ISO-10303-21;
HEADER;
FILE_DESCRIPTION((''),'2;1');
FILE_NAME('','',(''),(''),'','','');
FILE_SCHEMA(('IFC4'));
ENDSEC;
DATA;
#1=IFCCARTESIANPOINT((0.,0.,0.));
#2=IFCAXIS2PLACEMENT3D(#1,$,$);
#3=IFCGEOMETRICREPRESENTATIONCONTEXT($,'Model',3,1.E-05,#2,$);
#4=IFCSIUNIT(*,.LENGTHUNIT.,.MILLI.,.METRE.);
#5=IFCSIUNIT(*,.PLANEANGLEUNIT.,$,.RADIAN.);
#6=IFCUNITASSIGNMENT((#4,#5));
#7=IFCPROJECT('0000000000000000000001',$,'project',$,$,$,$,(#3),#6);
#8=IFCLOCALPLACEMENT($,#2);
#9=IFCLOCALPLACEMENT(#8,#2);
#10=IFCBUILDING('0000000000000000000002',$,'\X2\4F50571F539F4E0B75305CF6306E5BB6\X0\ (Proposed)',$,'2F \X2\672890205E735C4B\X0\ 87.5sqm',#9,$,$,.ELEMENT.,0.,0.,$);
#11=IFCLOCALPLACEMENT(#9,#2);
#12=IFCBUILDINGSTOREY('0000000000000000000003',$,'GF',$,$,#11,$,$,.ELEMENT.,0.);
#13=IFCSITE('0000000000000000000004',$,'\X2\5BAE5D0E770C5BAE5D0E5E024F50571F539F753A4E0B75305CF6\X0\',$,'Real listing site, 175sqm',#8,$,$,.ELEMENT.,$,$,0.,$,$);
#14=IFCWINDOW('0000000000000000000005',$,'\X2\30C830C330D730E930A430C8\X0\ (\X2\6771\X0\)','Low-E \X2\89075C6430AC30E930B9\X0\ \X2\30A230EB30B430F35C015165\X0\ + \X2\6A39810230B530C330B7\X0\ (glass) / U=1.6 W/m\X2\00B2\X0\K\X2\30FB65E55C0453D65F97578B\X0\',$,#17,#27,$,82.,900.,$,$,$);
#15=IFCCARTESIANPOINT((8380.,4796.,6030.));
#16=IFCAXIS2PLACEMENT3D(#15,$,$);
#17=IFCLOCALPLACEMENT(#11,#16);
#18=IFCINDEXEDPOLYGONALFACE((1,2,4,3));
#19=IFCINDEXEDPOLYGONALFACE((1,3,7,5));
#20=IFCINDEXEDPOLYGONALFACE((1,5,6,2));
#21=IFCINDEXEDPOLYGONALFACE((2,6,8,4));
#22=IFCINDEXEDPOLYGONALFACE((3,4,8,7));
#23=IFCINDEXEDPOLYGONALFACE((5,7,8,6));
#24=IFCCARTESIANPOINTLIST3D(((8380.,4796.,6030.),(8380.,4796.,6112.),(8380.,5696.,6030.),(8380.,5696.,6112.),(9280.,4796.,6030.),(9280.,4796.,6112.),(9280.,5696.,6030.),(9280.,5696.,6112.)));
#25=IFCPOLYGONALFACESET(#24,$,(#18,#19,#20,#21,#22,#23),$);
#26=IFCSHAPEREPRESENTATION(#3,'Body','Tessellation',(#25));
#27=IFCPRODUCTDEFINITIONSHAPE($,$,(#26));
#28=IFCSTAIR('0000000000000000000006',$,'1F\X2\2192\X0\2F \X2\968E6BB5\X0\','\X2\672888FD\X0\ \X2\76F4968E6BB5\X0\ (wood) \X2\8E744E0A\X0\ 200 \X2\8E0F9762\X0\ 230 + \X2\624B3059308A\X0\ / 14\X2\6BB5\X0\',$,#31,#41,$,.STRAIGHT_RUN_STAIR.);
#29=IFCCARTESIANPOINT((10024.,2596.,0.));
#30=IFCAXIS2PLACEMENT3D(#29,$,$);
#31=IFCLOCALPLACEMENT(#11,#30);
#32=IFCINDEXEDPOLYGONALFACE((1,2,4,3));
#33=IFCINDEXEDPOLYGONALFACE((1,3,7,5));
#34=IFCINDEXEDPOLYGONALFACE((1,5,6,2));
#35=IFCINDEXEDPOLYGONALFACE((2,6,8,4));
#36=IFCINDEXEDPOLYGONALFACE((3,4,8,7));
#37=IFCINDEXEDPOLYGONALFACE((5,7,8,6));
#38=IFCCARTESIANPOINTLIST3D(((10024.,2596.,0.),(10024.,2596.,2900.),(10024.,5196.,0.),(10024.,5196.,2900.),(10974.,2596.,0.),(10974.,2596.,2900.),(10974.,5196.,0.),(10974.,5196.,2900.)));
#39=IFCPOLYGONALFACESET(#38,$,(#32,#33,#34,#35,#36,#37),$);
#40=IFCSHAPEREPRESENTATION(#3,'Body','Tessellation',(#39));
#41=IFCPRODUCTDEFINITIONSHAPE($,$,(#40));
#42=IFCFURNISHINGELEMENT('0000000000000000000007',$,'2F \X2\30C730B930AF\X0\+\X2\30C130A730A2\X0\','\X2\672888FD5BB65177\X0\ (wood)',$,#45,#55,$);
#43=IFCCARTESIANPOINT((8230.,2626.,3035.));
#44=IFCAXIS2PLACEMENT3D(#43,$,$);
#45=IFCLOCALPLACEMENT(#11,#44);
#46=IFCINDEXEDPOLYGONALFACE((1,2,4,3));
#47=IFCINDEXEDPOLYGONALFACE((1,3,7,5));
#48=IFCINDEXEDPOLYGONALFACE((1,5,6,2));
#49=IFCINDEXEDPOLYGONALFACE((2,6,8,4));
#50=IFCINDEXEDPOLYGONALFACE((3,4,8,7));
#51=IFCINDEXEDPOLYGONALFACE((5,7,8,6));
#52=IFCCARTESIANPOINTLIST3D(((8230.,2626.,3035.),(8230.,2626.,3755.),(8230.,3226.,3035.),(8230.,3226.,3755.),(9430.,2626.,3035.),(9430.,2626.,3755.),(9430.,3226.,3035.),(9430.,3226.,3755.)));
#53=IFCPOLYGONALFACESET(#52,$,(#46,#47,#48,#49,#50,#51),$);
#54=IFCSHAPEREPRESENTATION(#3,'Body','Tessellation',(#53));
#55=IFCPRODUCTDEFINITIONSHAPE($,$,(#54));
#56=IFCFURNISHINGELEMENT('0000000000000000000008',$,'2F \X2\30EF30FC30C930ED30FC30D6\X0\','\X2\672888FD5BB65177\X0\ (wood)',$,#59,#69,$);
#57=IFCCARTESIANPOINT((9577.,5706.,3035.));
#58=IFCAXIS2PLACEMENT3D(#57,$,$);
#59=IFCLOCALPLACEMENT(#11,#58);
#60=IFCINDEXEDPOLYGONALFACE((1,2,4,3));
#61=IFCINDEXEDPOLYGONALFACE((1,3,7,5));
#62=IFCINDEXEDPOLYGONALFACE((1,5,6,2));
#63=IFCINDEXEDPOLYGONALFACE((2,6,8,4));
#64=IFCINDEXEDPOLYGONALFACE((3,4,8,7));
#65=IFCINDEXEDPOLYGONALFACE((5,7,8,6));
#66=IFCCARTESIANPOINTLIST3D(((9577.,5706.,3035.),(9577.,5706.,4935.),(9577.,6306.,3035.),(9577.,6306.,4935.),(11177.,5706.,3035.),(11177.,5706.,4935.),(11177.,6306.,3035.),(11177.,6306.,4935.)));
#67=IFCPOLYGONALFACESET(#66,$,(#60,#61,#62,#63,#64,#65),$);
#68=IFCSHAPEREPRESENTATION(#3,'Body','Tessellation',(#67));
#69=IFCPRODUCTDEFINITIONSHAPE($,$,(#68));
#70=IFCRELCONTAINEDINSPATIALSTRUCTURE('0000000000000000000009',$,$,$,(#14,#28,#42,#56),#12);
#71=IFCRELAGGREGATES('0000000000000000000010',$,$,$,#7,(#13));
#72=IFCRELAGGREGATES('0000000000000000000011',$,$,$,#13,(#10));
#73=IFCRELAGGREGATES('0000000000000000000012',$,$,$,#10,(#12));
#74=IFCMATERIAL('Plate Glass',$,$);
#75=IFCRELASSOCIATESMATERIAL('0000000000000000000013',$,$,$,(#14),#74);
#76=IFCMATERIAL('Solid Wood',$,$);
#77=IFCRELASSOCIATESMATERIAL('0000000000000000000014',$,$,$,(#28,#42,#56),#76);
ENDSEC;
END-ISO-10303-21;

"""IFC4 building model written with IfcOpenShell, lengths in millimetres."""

from ifc_helpers import new_model, si_unit, frame, frame_2d, origin, place, context, project, spatial, rectangle, extrude, material, element, save


model = new_model("IFC4")

# Units and contexts
model_context = context("Model", 3, precision=1e-05, world=origin())
ifc_project = project(units=[si_unit("LENGTHUNIT", "METRE", prefix="MILLI"), si_unit("PLANEANGLEUNIT", "RADIAN")], contexts=[model_context])

# Site, building, storey
site_placement = place(None, origin())
site = spatial("IfcSite", under=ifc_project, at=site_placement, Name="宮崎県宮崎市佐土原町下田島", ObjectType="Real listing site, 175sqm", CompositionType="ELEMENT", RefElevation=0.0)
building_placement = place(site_placement, origin())
building = spatial("IfcBuilding", under=site, at=building_placement, Name="佐土原下田島の家 (Proposed)", ObjectType="2F 木造平屋 87.5sqm", CompositionType="ELEMENT", ElevationOfRefHeight=0.0, ElevationOfTerrain=0.0)
storey_placement = place(building_placement, origin())
storey = spatial("IfcBuildingStorey", under=building, at=storey_placement, Name="GF", CompositionType="ELEMENT", Elevation=0.0)

# Shared definitions
ifc_material_1 = material(Name="Solid Wood")

# Shared definitions
ifc_material_2 = material(Name="Plate Glass")

# Window
window_1_placement = place(storey_placement, frame((8380.0, 4796.0, 6030.0)))
element("IfcWindow", 1, at=window_1_placement, inside=storey, material=ifc_material_2, Name="トップライト (東)", Description="Low-E 複層ガラス アルゴン封入 + 樹脂サッシ (glass) / U=1.6 W/m²K・日射取得型", OverallHeight=82.0, OverallWidth=900.0, context=model_context, shape_type="SweptSolid", body=[
    extrude(rectangle(XDim=900.0, YDim=900.0, at=frame_2d((450.0, 450.0))), frame((8380.0, 4796.0, 6030.0)), (0.0, 0.0, 1.0), 82.0),
])

# Stair
stair_placement = place(storey_placement, frame((10024.0, 2596.0, 0.0)))
element("IfcStair", 2, at=stair_placement, inside=storey, material=ifc_material_1, Name="1F→2F 階段", Description="木製 直階段 (wood) 蹴上 200 踏面 230 + 手すり / 14段", PredefinedType="STRAIGHT_RUN_STAIR", context=model_context, shape_type="SweptSolid", body=[
    extrude(rectangle(XDim=950.0, YDim=2600.0, at=frame_2d((475.0, 1300.0))), frame((10024.0, 2596.0, 0.0)), (0.0, 0.0, 1.0), 2900.0),
])

# Furnishing elements
furnishing_1_placement = place(storey_placement, frame((8230.0, 2626.0, 3035.0)))
element("IfcFurnishingElement", 3, at=furnishing_1_placement, inside=storey, material=ifc_material_1, Name="2F デスク+チェア", Description="木製家具 (wood)", context=model_context, shape_type="SweptSolid", body=[
    extrude(rectangle(XDim=1200.0, YDim=600.0, at=frame_2d((600.0, 300.0))), frame((8230.0, 2626.0, 3035.0)), (0.0, 0.0, 1.0), 720.0),
])
furnishing_2_placement = place(storey_placement, frame((9577.0, 5706.0, 3035.0)))
element("IfcFurnishingElement", 4, at=furnishing_2_placement, inside=storey, material=ifc_material_1, Name="2F ワードローブ", Description="木製家具 (wood)", context=model_context, shape_type="SweptSolid", body=[
    extrude(rectangle(XDim=1600.0, YDim=600.0, at=frame_2d((800.0, 300.0))), frame((9577.0, 5706.0, 3035.0)), (0.0, 0.0, 1.0), 1900.0),
])

save(model, "model.ifc")
